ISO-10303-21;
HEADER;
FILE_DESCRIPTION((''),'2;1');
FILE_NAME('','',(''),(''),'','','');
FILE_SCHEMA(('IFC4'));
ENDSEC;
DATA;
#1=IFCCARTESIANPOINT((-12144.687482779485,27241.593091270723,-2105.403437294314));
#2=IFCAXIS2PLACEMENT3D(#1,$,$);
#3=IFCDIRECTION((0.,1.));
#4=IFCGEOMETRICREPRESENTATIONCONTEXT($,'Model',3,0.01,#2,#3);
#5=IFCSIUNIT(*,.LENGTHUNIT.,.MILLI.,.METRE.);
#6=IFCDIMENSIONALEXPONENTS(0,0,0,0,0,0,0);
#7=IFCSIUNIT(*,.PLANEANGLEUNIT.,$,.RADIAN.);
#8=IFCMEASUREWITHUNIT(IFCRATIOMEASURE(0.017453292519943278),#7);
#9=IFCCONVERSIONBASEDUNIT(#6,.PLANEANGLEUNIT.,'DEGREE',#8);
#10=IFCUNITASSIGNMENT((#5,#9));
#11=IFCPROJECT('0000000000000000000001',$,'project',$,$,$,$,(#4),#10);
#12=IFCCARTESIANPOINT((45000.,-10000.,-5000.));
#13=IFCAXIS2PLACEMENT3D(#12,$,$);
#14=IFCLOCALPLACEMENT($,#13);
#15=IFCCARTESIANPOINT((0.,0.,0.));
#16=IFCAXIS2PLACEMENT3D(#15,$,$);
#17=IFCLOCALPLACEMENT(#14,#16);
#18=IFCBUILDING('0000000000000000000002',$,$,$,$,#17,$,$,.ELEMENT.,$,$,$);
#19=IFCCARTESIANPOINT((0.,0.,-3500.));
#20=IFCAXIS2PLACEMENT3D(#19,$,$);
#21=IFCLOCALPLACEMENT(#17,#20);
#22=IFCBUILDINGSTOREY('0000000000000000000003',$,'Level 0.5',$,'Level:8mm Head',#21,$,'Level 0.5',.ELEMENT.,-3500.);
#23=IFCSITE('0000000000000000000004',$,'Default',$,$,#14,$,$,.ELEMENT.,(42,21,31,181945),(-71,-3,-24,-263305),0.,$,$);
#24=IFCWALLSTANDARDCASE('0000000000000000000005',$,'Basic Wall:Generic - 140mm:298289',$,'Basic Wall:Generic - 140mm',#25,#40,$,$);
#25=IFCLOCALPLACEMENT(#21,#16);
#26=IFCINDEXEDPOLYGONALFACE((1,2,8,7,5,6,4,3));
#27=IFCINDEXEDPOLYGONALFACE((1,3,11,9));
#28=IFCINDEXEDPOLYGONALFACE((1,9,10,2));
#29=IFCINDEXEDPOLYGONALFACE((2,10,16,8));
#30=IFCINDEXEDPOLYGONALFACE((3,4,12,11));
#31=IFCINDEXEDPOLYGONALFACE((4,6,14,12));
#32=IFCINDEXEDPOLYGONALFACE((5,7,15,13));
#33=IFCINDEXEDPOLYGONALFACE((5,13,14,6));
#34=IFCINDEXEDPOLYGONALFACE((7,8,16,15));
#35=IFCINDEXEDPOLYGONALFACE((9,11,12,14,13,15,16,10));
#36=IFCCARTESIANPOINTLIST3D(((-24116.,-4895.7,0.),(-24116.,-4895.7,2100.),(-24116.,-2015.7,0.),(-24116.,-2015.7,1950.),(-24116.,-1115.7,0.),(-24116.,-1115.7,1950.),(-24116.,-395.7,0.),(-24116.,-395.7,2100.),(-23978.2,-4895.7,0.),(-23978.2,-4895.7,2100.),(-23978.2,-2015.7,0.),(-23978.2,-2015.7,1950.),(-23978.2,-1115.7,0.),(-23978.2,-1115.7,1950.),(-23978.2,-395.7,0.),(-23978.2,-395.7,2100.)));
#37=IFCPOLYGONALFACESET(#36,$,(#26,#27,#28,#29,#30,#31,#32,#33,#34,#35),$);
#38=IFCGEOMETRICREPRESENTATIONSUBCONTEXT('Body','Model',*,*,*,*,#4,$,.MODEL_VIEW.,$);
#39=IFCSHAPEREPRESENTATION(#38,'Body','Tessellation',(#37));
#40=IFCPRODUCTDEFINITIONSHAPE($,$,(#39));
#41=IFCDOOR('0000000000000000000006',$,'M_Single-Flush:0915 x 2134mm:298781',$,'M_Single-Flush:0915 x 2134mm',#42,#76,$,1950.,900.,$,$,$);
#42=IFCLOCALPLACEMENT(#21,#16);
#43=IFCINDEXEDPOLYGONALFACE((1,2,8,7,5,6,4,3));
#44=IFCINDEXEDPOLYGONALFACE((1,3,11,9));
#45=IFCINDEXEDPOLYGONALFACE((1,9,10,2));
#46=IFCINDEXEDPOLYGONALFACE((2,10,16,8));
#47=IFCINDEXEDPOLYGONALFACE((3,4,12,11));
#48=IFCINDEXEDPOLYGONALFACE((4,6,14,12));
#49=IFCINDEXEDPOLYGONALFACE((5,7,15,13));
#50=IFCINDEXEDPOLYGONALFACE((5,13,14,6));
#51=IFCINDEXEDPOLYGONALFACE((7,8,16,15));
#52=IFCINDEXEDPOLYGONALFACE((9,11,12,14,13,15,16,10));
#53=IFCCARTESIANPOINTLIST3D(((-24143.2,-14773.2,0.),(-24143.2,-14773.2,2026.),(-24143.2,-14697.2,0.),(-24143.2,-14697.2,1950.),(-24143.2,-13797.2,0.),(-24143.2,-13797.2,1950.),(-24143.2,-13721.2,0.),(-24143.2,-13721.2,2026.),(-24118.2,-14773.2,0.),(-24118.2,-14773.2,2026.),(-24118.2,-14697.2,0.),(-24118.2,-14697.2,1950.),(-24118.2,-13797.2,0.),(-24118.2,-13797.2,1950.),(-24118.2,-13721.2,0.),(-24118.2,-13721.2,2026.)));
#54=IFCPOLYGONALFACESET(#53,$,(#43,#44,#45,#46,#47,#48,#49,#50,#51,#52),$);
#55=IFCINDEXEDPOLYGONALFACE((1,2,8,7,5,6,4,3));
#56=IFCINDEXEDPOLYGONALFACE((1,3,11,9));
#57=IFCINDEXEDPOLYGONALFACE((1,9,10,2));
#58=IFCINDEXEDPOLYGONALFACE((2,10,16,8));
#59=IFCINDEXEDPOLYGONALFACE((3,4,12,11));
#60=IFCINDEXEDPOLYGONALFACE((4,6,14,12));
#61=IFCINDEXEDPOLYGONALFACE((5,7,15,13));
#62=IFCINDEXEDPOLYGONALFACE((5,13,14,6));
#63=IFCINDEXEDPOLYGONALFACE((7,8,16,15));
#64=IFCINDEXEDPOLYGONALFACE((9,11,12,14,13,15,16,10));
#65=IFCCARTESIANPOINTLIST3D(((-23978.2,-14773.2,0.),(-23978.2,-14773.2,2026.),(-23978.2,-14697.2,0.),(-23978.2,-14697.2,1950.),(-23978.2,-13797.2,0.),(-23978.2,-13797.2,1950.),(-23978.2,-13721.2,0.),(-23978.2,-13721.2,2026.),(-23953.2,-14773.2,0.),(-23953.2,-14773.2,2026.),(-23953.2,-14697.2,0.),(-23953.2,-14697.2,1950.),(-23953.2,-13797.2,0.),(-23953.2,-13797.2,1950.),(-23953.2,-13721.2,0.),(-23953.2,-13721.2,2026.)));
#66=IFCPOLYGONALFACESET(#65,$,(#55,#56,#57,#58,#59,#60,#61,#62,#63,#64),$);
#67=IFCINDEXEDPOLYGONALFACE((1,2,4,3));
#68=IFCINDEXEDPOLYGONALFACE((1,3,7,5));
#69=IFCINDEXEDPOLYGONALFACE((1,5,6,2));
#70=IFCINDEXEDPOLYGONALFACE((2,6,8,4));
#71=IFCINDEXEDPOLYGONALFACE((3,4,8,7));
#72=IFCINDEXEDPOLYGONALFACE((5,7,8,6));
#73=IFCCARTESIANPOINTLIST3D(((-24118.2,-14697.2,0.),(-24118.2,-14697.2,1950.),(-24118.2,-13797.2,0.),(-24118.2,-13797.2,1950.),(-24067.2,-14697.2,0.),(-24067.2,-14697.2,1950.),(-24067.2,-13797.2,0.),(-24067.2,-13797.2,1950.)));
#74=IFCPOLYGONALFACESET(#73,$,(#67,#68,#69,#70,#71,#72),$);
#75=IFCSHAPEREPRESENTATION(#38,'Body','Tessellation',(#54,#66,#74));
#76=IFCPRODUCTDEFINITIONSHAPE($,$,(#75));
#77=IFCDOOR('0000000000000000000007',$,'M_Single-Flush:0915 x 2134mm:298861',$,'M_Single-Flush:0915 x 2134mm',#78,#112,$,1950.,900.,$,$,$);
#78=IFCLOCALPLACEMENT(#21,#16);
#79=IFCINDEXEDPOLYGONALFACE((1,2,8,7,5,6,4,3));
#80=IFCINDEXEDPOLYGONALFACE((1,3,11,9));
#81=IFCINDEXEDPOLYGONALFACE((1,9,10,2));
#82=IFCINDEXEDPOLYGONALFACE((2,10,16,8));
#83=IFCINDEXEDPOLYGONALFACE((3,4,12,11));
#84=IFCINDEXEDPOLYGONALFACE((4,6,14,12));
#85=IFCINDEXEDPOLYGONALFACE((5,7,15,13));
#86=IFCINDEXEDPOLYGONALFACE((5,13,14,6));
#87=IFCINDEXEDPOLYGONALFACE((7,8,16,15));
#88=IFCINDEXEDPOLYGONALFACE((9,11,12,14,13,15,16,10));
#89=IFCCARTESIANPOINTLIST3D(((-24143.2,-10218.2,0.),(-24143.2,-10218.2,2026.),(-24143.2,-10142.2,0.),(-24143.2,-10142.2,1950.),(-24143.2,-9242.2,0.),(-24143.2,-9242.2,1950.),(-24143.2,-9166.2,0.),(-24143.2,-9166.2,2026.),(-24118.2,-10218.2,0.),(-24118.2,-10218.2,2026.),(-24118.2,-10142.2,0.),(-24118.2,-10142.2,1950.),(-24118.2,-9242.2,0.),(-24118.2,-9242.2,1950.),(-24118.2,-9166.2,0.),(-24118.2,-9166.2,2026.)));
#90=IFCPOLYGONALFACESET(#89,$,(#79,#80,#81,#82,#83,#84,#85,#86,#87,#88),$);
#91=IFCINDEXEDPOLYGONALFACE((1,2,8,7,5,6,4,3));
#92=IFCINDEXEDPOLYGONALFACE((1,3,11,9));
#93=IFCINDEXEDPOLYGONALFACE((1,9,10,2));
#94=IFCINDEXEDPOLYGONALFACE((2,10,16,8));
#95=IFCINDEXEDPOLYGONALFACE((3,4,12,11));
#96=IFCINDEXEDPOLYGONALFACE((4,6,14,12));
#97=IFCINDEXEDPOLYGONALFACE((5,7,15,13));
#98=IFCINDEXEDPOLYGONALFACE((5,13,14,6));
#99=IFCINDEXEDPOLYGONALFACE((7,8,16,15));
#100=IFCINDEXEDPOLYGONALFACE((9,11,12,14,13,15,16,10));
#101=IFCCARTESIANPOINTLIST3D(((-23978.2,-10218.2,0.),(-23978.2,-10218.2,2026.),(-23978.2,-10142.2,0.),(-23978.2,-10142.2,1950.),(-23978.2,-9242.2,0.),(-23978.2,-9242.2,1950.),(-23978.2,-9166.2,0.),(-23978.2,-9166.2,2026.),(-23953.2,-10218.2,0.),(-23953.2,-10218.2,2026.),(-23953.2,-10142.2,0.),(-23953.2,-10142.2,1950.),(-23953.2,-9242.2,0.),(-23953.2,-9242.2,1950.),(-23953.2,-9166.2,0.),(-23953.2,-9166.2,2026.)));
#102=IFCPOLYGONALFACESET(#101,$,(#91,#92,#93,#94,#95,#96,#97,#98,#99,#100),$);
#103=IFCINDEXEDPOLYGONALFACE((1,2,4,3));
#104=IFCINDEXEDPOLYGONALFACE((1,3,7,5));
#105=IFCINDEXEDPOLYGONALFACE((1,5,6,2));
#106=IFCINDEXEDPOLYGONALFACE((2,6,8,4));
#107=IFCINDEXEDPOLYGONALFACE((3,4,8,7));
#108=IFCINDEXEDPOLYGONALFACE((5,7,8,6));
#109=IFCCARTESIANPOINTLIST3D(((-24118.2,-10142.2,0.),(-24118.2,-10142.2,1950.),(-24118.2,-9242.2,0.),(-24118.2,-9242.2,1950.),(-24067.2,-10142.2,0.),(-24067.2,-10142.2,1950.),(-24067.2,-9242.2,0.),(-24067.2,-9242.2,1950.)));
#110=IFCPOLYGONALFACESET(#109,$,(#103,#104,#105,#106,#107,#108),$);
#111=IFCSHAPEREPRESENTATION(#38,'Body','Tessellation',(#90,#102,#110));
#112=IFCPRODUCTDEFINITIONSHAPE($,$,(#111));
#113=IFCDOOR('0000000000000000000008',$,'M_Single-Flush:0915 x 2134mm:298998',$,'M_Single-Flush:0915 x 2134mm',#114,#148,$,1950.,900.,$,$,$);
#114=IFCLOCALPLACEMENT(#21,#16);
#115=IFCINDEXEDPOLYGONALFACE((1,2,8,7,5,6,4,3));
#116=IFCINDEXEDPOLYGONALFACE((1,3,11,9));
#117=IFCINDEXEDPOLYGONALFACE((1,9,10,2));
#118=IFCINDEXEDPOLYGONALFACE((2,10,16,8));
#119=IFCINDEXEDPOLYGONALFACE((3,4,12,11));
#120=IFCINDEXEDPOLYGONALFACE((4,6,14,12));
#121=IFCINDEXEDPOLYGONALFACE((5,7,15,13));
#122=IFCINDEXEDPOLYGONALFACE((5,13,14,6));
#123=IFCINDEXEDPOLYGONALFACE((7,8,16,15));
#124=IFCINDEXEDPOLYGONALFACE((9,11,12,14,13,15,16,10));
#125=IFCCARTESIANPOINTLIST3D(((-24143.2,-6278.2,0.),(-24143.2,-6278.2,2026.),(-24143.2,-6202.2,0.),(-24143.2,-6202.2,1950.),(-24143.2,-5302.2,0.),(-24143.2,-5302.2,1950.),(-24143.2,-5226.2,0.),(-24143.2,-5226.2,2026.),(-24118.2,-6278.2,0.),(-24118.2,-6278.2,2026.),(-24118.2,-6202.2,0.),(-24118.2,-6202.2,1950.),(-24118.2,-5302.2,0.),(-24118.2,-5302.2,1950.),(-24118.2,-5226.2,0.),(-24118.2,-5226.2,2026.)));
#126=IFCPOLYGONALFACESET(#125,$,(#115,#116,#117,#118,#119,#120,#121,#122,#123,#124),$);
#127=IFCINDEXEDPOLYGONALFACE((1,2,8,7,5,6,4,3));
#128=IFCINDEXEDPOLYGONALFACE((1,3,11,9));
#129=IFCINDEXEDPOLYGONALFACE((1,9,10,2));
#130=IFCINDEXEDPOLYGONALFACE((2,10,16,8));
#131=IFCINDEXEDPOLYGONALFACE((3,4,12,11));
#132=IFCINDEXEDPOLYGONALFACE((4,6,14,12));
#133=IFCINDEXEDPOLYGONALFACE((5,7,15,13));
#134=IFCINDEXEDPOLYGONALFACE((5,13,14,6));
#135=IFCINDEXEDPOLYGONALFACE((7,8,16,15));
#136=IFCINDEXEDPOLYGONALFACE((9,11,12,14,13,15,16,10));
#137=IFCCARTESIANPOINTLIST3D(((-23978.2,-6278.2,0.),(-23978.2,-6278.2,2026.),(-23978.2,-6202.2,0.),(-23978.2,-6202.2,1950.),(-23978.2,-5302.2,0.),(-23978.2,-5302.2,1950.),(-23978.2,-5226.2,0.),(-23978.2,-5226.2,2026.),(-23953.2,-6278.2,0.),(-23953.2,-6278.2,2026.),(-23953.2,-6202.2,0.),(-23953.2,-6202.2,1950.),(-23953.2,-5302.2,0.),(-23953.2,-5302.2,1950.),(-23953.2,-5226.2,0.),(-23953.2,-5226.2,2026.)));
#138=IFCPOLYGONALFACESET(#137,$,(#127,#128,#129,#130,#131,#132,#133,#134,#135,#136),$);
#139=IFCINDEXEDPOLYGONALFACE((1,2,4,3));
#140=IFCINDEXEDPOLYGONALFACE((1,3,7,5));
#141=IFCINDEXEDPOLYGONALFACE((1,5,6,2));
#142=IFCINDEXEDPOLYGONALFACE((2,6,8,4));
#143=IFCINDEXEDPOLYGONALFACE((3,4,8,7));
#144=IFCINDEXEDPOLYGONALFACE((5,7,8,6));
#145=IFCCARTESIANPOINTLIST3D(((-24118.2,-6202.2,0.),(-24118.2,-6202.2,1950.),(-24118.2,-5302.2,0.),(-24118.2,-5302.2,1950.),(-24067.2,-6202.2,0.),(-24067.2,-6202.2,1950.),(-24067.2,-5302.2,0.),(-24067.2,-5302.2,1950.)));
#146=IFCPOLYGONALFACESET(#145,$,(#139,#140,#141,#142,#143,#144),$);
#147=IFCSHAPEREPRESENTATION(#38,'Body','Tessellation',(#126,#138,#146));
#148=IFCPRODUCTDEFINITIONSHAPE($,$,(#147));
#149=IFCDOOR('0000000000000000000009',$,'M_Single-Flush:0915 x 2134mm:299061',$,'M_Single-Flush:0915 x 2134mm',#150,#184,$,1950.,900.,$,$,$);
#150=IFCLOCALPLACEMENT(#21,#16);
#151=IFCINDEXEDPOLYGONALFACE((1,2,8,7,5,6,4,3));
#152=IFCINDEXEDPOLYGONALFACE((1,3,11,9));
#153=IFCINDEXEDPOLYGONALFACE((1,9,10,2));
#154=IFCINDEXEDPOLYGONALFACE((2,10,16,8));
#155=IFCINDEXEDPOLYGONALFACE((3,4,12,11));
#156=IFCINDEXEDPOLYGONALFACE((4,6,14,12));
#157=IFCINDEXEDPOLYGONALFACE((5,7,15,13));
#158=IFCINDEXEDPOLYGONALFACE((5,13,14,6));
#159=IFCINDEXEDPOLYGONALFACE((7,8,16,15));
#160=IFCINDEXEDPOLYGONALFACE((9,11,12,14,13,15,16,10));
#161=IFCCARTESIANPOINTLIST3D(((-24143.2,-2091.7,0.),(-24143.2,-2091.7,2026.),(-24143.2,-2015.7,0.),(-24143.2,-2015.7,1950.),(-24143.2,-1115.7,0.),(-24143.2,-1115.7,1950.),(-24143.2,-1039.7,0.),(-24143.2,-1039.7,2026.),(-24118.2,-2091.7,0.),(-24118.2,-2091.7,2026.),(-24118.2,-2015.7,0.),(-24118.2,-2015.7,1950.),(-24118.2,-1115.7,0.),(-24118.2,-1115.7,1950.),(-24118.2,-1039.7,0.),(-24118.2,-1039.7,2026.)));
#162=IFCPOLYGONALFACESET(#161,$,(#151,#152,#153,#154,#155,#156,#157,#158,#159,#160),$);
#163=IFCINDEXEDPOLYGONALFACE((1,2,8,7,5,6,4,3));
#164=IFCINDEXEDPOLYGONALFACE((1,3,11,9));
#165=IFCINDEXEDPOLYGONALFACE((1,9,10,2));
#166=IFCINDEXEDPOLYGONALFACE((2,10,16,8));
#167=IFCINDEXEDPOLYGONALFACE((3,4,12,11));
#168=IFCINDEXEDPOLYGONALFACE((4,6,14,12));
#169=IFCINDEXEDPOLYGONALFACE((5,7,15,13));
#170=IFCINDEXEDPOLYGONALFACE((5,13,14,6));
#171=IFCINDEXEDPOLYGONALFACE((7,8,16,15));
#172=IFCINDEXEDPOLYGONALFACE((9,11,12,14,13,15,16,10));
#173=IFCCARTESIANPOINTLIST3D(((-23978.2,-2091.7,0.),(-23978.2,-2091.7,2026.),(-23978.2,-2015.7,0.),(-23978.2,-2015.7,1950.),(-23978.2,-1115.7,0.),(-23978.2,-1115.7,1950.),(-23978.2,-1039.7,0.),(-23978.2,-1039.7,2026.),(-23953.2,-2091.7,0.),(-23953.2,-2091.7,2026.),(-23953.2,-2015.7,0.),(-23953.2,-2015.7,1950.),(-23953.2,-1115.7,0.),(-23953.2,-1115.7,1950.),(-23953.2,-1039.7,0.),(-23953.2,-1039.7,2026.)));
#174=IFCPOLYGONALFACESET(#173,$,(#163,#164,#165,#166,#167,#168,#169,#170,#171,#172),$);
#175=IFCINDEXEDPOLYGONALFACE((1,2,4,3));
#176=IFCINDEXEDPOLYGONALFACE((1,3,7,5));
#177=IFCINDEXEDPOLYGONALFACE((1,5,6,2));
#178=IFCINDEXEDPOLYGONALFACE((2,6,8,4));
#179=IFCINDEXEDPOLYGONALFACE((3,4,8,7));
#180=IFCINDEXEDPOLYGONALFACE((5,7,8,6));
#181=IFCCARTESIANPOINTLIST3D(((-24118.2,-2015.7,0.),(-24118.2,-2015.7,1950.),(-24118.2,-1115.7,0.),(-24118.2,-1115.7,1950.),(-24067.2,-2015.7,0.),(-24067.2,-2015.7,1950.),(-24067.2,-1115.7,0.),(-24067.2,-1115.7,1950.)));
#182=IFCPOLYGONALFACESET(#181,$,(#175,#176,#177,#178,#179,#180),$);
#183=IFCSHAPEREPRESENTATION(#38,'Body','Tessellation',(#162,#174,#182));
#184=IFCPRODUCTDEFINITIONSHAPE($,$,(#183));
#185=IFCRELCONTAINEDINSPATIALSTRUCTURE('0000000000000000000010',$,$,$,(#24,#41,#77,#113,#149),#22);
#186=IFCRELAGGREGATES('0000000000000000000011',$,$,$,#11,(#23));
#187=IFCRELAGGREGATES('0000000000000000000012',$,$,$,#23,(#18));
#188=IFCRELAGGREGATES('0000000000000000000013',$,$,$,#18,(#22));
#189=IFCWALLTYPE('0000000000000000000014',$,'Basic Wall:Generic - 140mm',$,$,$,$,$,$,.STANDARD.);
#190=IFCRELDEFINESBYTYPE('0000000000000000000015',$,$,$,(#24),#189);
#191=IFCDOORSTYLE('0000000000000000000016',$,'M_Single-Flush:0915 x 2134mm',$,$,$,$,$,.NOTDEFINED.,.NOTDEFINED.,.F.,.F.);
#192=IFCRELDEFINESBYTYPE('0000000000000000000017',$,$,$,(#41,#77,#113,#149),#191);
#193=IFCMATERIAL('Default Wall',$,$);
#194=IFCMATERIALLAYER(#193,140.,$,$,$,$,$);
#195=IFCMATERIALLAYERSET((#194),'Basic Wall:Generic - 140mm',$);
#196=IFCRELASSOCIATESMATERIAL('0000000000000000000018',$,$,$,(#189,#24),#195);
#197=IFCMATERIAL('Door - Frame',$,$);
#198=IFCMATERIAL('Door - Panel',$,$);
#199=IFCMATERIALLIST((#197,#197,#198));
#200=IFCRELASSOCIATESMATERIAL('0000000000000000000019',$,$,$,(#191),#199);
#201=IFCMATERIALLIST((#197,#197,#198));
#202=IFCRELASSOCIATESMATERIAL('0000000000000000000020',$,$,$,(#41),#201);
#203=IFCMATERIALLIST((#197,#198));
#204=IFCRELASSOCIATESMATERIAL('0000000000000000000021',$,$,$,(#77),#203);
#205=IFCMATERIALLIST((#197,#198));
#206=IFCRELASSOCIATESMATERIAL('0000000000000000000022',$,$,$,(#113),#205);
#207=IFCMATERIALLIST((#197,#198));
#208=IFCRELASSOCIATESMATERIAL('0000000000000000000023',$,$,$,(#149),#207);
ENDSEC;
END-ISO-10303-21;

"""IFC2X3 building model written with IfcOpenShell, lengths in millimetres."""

from ifc_helpers import new_model, entity, si_unit, converted_unit, direction, frame, frame_2d, origin, place, context, subcontext, project, spatial, polyline, rectangle, outline, extrude, clip, bounded_halfspace, source, transform, mapped, material, material_list, layer, layer_set, layer_usage, type_object, type_shapes, element, fill, save


model = new_model("IFC2X3")

# Units and contexts
model_context = context("Model", 3, precision=0.01, world=frame((-12144.687482779485, 27241.593091270723, -2105.403437294314)), true_north=direction((0.0, 1.0)))
body_context = subcontext(model_context, "Body", "Model", "MODEL_VIEW")
ifc_project = project(units=[si_unit("LENGTHUNIT", "METRE", prefix="MILLI"), converted_unit("PLANEANGLEUNIT", "DEGREE", entity("IfcRatioMeasure", 0.017453292519943278), si_unit("PLANEANGLEUNIT", "RADIAN"), dimensions=[0, 0, 0, 0, 0, 0, 0])], contexts=[model_context])

# Site, building, storey
site_placement = place(None, frame((45000.0, -10000.0, -5000.0)))
site = spatial("IfcSite", under=ifc_project, at=site_placement, Name="Default", CompositionType="ELEMENT", RefLatitude=(42, 21, 31, 181945), RefLongitude=(-71, -3, -24, -263305), RefElevation=0.0)
building_placement = place(site_placement, origin())
building = spatial("IfcBuilding", under=site, at=building_placement, CompositionType="ELEMENT")
storey_placement = place(building_placement, frame((0.0, 0.0, -3500.0)))
storey = spatial("IfcBuildingStorey", under=building, at=storey_placement, Name="Level 0.5", ObjectType="Level:8mm Head", LongName="Level 0.5", CompositionType="ELEMENT", Elevation=-3500.0)

# Shared definitions
ifc_material_1 = material(Name="Default Wall")

# Shared definitions
ifc_material_2 = material(Name="Door - Frame")
ifc_material_3 = material(Name="Door - Panel")

# Wall, openings, doors
ifc_layer_1 = layer(ifc_material_1, 140.0)
ifc_layer_set_1 = layer_set([ifc_layer_1], Name="Basic Wall:Generic - 140mm")
ifc_layer_usage_1 = layer_usage(ifc_layer_set_1, "AXIS2", "NEGATIVE", 70.0)
wall_type_1 = type_object("IfcWallType", Name="Basic Wall:Generic - 140mm", PredefinedType="STANDARD", material=ifc_layer_set_1)
wall_1_placement = place(storey_placement, frame((-24048.2, -395.7, 0.0), z_axis=(0.0, 0.0, 1.0), x_axis=(0.0, -1.0, 0.0)))
wall_1 = element("IfcWallStandardCase", 1, at=wall_1_placement, inside=storey, type_object=wall_type_1, material=ifc_layer_usage_1, Name="Basic Wall:Generic - 140mm:298289", ObjectType="Basic Wall:Generic - 140mm", context=body_context, shape_type="Clipping", body=[
    clip(extrude(rectangle(XDim=137.7, YDim=4500.0, at=frame_2d((2250.0, 1.1), x_axis=(0.0, 1.0))), origin(), (0.0, 0.0, 1.0), 2100.0), bounded_halfspace(frame((4500.0, -67.7, 2100.0), z_axis=(0.0, 0.0, -1.0), x_axis=(0.0, -1.0, 0.0)), True, frame((4500.0, -67.7, 2100.0)), polyline([(0.0, 0.0), (0.0, 41986.2), (-1371600.0, 41986.2), (-1371600.0, 0.0), (0.0, 0.0)]))),
])
opening_1_placement = place(wall_1_placement, frame((14301.5, 70.0, 0.0)))
opening_1 = element("IfcOpeningElement", 2, at=opening_1_placement, cuts=wall_1, ObjectType="Opening", context=body_context, shape_type="SweptSolid", body=[
    extrude(rectangle(XDim=900.0, YDim=1950.0, at=frame_2d((975.0, 450.0), x_axis=(0.0, -1.0))), frame((0.0, 0.0, 0.0), z_axis=(0.0, -1.0, 0.0), x_axis=(0.0, 0.0, 1.0)), (0.0, 0.0, 1.0), 140.0),
])
opening_2_placement = place(wall_1_placement, frame((9746.5, 70.0, 0.0)))
opening_2 = element("IfcOpeningElement", 3, at=opening_2_placement, cuts=wall_1, ObjectType="Opening", context=body_context, shape_type="SweptSolid", body=[
    extrude(rectangle(XDim=900.0, YDim=1950.0, at=frame_2d((975.0, 450.0), x_axis=(0.0, -1.0))), frame((0.0, 0.0, 0.0), z_axis=(0.0, -1.0, 0.0), x_axis=(0.0, 0.0, 1.0)), (0.0, 0.0, 1.0), 140.0),
])
opening_3_placement = place(wall_1_placement, frame((5806.5, 70.0, 0.0)))
opening_3 = element("IfcOpeningElement", 4, at=opening_3_placement, cuts=wall_1, ObjectType="Opening", context=body_context, shape_type="SweptSolid", body=[
    extrude(rectangle(XDim=900.0, YDim=1950.0, at=frame_2d((975.0, 450.0), x_axis=(0.0, -1.0))), frame((0.0, 0.0, 0.0), z_axis=(0.0, -1.0, 0.0), x_axis=(0.0, 0.0, 1.0)), (0.0, 0.0, 1.0), 140.0),
])
opening_4_placement = place(wall_1_placement, frame((1620.0, 70.0, 0.0)))
opening_4 = element("IfcOpeningElement", 5, at=opening_4_placement, cuts=wall_1, ObjectType="Opening", context=body_context, shape_type="SweptSolid", body=[
    extrude(rectangle(XDim=900.0, YDim=1950.0, at=frame_2d((975.0, 450.0), x_axis=(0.0, -1.0))), frame((0.0, 0.0, 0.0), z_axis=(0.0, -1.0, 0.0), x_axis=(0.0, 0.0, 1.0)), (0.0, 0.0, 1.0), 140.0),
])
ifc_material_list_1 = material_list([ifc_material_2, ifc_material_2, ifc_material_3])
ifc_material_list_2 = material_list([ifc_material_2, ifc_material_2, ifc_material_3])
door_style_1 = type_object("IfcDoorStyle", Name="M_Single-Flush:0915 x 2134mm", ConstructionType="NOTDEFINED", OperationType="NOTDEFINED", ParameterTakesPrecedence=False, Sizeable=False, material=ifc_material_list_2)
shared_shape_1 = source(origin(), body_context, "Body", "SweptSolid", [
    extrude(outline(polyline([(-526.0, -1032.0), (526.0, -1032.0), (526.0, 994.0), (450.0, 994.0), (450.0, -956.0), (-450.0, -956.0), (-450.0, 994.0), (-526.0, 994.0), (-526.0, -1032.0)])), frame((450.0, 165.0, 994.0), z_axis=(0.0, -1.0, 0.0), x_axis=(-1.0, 0.0, 0.0)), (0.0, 0.0, 1.0), 25.0),
    extrude(outline(polyline([(-1032.0, -526.0), (994.0, -526.0), (994.0, -450.0), (-956.0, -450.0), (-956.0, 450.0), (994.0, 450.0), (994.0, 526.0), (-1032.0, 526.0), (-1032.0, -526.0)])), frame((450.0, 0.0, 994.0), z_axis=(0.0, -1.0, 0.0), x_axis=(0.0, 0.0, -1.0)), (0.0, 0.0, 1.0), 25.0),
    extrude(rectangle(XDim=900.0, YDim=51.0, at=frame_2d((0.0, 0.0), x_axis=(1.0, 0.0))), frame((450.0, 114.5, 0.0)), (0.0, 0.0, 1.0), 1950.0),
])
type_shapes(door_style_1, [shared_shape_1])
door_1_placement = place(opening_1_placement, frame((0.0, 0.0, 0.0), z_axis=(0.0, 0.0, 1.0), x_axis=(-1.0, 0.0, 0.0)))
door_1 = element("IfcDoor", 6, at=door_1_placement, inside=storey, type_object=door_style_1, material=ifc_material_list_1, Name="M_Single-Flush:0915 x 2134mm:298781", ObjectType="M_Single-Flush:0915 x 2134mm", OverallHeight=1950.0, OverallWidth=900.0, context=body_context, shape_type="MappedRepresentation", body=[
    mapped(shared_shape_1, transform((0.0, 0.0, 0.0), scale=1.0)),
])
fill(opening_1, door_1)
ifc_material_list_3 = material_list([ifc_material_2, ifc_material_3])
door_2_placement = place(opening_2_placement, frame((0.0, 0.0, 0.0), z_axis=(0.0, 0.0, 1.0), x_axis=(-1.0, 0.0, 0.0)))
door_2 = element("IfcDoor", 7, at=door_2_placement, inside=storey, type_object=door_style_1, material=ifc_material_list_3, Name="M_Single-Flush:0915 x 2134mm:298861", ObjectType="M_Single-Flush:0915 x 2134mm", OverallHeight=1950.0, OverallWidth=900.0, context=body_context, shape_type="MappedRepresentation", body=[
    mapped(shared_shape_1, transform((0.0, 0.0, 0.0), scale=1.0)),
])
fill(opening_2, door_2)
ifc_material_list_4 = material_list([ifc_material_2, ifc_material_3])
door_3_placement = place(opening_3_placement, frame((0.0, 0.0, 0.0), z_axis=(0.0, 0.0, 1.0), x_axis=(-1.0, 0.0, 0.0)))
door_3 = element("IfcDoor", 8, at=door_3_placement, inside=storey, type_object=door_style_1, material=ifc_material_list_4, Name="M_Single-Flush:0915 x 2134mm:298998", ObjectType="M_Single-Flush:0915 x 2134mm", OverallHeight=1950.0, OverallWidth=900.0, context=body_context, shape_type="MappedRepresentation", body=[
    mapped(shared_shape_1, transform((0.0, 0.0, 0.0), scale=1.0)),
])
fill(opening_3, door_3)
ifc_material_list_5 = material_list([ifc_material_2, ifc_material_3])
door_4_placement = place(opening_4_placement, frame((0.0, 0.0, 0.0), z_axis=(0.0, 0.0, 1.0), x_axis=(-1.0, 0.0, 0.0)))
door_4 = element("IfcDoor", 9, at=door_4_placement, inside=storey, type_object=door_style_1, material=ifc_material_list_5, Name="M_Single-Flush:0915 x 2134mm:299061", ObjectType="M_Single-Flush:0915 x 2134mm", OverallHeight=1950.0, OverallWidth=900.0, context=body_context, shape_type="MappedRepresentation", body=[
    mapped(shared_shape_1, transform((0.0, 0.0, 0.0), scale=1.0)),
])
fill(opening_4, door_4)

save(model, "model.ifc")
